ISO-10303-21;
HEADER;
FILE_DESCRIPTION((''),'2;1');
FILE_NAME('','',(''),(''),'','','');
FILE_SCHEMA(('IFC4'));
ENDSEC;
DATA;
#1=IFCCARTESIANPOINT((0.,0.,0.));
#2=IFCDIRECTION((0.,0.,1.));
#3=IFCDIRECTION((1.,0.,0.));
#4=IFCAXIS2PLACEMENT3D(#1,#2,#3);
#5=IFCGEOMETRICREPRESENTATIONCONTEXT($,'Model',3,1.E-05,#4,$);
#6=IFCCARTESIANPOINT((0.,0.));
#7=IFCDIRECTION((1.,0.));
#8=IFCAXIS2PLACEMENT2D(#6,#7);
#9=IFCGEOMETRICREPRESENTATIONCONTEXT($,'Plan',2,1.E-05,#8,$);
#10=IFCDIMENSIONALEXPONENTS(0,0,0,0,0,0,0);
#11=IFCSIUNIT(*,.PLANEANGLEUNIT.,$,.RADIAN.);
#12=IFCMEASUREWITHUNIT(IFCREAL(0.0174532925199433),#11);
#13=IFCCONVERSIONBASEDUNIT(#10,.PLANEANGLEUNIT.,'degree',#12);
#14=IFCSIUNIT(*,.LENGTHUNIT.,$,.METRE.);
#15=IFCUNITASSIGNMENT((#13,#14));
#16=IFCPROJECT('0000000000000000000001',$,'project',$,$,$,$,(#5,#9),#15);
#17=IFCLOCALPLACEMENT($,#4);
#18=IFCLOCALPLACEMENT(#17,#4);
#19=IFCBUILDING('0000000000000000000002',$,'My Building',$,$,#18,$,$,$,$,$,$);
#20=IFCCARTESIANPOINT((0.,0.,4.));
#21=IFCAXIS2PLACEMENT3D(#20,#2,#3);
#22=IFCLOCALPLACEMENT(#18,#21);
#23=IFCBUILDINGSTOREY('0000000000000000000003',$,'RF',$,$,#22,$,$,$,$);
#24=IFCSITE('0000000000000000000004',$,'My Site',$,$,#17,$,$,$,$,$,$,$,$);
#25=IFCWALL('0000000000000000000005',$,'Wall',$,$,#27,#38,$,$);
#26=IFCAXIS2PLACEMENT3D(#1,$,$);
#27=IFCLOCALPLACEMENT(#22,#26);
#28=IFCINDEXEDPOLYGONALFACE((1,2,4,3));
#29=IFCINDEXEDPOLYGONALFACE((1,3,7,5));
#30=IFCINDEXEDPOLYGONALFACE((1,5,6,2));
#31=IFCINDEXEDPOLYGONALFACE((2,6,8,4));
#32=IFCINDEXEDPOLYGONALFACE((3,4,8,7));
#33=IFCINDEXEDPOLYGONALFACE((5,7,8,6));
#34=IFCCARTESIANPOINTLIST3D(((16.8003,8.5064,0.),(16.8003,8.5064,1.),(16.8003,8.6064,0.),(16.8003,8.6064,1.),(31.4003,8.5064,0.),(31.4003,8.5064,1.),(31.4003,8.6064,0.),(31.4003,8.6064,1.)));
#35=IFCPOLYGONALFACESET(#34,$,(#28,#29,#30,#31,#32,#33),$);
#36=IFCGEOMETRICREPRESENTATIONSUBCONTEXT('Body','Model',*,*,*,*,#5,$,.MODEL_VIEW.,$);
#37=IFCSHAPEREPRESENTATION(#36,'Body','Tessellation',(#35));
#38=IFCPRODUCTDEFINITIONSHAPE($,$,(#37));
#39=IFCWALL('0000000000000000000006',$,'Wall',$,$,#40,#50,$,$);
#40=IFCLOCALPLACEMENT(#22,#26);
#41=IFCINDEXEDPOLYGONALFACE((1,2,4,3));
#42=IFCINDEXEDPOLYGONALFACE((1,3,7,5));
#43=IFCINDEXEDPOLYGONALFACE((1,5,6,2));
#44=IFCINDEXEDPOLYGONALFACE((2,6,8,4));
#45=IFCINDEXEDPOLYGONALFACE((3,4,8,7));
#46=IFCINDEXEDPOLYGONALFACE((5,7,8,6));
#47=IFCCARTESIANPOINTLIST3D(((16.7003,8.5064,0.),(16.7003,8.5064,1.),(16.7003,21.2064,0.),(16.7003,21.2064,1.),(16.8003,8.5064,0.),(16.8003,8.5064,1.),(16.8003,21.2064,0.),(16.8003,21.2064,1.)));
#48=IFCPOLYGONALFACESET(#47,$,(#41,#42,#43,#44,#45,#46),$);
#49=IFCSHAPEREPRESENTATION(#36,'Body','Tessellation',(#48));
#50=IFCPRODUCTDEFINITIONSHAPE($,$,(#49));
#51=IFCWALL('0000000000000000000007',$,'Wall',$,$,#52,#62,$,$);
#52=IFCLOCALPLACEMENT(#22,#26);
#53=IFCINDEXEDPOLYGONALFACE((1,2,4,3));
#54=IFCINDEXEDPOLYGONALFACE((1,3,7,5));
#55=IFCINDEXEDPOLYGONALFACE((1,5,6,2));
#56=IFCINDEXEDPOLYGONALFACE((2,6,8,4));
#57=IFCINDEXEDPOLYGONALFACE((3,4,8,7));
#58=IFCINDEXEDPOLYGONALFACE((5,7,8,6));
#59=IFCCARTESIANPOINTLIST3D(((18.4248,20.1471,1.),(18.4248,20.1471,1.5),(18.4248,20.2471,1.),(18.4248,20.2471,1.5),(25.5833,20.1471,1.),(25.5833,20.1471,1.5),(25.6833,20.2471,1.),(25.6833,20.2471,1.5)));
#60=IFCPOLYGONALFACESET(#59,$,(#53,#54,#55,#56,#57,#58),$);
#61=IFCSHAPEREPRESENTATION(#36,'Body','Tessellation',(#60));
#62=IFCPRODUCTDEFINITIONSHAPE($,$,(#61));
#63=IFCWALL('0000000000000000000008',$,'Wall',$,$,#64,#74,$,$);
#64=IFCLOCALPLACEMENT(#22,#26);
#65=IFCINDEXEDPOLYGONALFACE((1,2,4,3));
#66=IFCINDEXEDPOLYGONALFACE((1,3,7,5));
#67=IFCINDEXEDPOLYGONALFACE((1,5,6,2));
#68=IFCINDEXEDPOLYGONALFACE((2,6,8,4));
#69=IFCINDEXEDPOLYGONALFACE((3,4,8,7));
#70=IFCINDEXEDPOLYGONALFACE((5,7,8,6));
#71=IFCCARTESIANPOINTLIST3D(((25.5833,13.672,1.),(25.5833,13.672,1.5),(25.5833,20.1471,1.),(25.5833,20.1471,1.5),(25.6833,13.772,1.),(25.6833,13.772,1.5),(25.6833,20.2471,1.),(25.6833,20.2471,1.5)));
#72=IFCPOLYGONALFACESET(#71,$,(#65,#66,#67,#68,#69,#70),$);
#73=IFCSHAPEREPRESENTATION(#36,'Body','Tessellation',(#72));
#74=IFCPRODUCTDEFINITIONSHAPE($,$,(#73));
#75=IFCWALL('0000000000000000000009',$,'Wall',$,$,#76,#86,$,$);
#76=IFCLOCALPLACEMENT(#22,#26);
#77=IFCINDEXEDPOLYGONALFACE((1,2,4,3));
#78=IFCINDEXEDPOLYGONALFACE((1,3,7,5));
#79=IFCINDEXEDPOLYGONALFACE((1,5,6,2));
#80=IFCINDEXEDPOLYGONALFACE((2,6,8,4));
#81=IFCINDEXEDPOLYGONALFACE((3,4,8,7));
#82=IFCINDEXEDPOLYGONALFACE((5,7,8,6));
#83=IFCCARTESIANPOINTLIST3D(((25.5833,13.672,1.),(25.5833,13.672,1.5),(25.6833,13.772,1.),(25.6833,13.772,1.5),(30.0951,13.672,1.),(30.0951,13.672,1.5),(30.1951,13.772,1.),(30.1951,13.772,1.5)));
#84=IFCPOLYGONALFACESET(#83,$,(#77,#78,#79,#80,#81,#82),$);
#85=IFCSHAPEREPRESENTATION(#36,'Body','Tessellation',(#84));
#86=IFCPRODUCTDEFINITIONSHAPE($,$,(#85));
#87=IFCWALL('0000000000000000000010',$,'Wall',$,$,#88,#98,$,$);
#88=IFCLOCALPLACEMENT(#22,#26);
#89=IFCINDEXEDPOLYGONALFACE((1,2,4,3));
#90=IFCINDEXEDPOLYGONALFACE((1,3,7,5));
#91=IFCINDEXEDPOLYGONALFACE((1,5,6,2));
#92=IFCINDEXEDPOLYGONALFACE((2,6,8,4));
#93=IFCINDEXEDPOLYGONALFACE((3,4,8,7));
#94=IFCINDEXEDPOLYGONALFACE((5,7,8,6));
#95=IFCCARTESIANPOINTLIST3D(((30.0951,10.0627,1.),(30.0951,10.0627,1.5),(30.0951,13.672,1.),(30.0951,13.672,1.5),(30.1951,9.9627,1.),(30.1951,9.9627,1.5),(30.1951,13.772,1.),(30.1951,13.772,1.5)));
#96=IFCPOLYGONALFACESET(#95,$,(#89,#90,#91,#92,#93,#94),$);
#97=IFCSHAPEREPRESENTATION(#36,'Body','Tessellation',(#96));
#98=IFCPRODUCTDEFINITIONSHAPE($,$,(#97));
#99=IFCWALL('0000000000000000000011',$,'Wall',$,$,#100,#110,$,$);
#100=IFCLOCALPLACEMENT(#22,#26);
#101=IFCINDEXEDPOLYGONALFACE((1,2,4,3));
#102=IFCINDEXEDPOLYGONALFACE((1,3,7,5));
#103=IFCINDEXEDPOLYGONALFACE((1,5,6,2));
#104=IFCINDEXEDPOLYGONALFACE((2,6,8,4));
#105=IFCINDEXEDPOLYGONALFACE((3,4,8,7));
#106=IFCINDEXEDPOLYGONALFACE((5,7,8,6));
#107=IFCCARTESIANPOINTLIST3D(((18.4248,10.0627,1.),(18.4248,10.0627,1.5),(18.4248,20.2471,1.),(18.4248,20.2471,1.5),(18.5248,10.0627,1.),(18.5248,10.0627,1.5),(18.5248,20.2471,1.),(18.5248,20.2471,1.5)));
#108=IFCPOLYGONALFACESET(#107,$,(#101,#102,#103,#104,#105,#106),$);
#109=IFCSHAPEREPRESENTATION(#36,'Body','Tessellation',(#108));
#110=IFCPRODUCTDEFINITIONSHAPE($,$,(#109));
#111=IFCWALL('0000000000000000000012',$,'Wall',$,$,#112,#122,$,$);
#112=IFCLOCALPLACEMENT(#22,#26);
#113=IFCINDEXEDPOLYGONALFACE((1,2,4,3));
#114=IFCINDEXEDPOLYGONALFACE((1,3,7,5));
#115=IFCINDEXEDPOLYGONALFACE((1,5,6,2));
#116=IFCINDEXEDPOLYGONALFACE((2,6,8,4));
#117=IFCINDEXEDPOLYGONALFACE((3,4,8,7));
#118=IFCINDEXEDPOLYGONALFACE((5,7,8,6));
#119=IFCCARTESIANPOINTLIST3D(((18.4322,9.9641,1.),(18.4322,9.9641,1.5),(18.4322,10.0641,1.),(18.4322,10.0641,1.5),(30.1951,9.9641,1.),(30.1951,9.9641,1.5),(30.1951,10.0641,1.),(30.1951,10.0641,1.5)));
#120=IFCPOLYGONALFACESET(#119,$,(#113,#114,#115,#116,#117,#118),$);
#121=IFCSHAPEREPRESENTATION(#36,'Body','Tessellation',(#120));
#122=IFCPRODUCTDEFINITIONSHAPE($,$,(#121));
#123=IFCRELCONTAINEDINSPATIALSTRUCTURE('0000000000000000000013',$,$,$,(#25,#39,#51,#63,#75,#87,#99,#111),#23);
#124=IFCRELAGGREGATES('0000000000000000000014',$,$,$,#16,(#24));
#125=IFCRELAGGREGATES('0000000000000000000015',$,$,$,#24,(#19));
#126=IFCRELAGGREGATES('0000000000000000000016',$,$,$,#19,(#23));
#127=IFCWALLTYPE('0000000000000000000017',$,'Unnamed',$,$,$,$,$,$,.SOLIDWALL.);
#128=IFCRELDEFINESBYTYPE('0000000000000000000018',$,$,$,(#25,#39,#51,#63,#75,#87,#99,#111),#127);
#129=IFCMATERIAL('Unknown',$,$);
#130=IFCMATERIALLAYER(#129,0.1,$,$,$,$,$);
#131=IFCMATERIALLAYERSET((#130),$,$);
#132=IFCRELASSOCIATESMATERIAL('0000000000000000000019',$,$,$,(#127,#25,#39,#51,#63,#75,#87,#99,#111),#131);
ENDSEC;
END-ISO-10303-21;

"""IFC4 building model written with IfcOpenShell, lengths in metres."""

from ifc_helpers import new_model, entity, si_unit, converted_unit, frame, origin_with_axes, origin_2d_with_axis, place, context, subcontext, project, spatial, line, indexed_curve, outline, extrude, material, layer, layer_set, layer_usage, type_object, element, save


model = new_model("IFC4")

# Units and contexts
model_context = context("Model", 3, precision=1e-05, world=origin_with_axes())
plan_context = context("Plan", 2, precision=1e-05, world=origin_2d_with_axis())
body_context = subcontext(model_context, "Body", "Model", "MODEL_VIEW")
ifc_project = project(units=[converted_unit("PLANEANGLEUNIT", "degree", entity("IfcReal", 0.0174532925199433), si_unit("PLANEANGLEUNIT", "RADIAN"), dimensions=[0, 0, 0, 0, 0, 0, 0]), si_unit("LENGTHUNIT", "METRE")], contexts=[model_context, plan_context])

# Site, building, storey
site_placement = place(None, origin_with_axes())
site = spatial("IfcSite", under=ifc_project, at=site_placement, Name="My Site")
building_placement = place(site_placement, origin_with_axes())
building = spatial("IfcBuilding", under=site, at=building_placement, Name="My Building")
storey_placement = place(building_placement, frame((0.0, 0.0, 4.0), z_axis=(0.0, 0.0, 1.0), x_axis=(1.0, 0.0, 0.0)))
storey = spatial("IfcBuildingStorey", under=building, at=storey_placement, Name="RF")

# Shared definitions
ifc_material = material(Name="Unknown")

# Walls
ifc_layer_1 = layer(ifc_material, 0.1)
ifc_layer_set_1 = layer_set([ifc_layer_1])
wall_type = type_object("IfcWallType", Name="Unnamed", PredefinedType="SOLIDWALL", material=ifc_layer_set_1)
ifc_layer_usage_1 = layer_usage(ifc_layer_set_1, "AXIS2", "POSITIVE", 0.0)
wall_1_placement = place(storey_placement, frame((16.8003, 8.5064, 0.0), z_axis=(0.0, 0.0, 1.0), x_axis=(1.0, 0.0, 0.0)))
element("IfcWall", 1, at=wall_1_placement, inside=storey, type_object=wall_type, material=ifc_layer_usage_1, Name="Wall", context=body_context, shape_type="SweptSolid", body=[
    extrude(outline(indexed_curve([(0.0, 0.0), (0.0, 0.1), (14.6, 0.1), (14.6, 0.0)], segments=[line(1, 2, 3, 4, 1)])), origin_with_axes(), (0.0, 0.0, 1.0), 1.0),
])
ifc_layer_usage_2 = layer_usage(ifc_layer_set_1, "AXIS2", "POSITIVE", 0.0)
wall_2_placement = place(storey_placement, frame((16.7003, 21.2064, 0.0), z_axis=(0.0, 0.0, 1.0), x_axis=(0.0, -1.0, 0.0)))
element("IfcWall", 2, at=wall_2_placement, inside=storey, type_object=wall_type, material=ifc_layer_usage_2, Name="Wall", context=body_context, shape_type="SweptSolid", body=[
    extrude(outline(indexed_curve([(0.0, 0.0), (0.0, 0.1), (12.7, 0.1), (12.7, 0.0)], segments=[line(1, 2, 3, 4, 1)])), origin_with_axes(), (0.0, 0.0, 1.0), 1.0),
])
ifc_layer_usage_3 = layer_usage(ifc_layer_set_1, "AXIS2", "POSITIVE", 0.0)
wall_3_placement = place(storey_placement, frame((18.4248, 20.1471, 1.0), z_axis=(0.0, 0.0, 1.0), x_axis=(1.0, 0.0, 0.0)))
element("IfcWall", 3, at=wall_3_placement, inside=storey, type_object=wall_type, material=ifc_layer_usage_3, Name="Wall", context=body_context, shape_type="SweptSolid", body=[
    extrude(outline(indexed_curve([(0.0, 0.0), (0.0, 0.1), (7.2584, 0.1), (7.1584, 0.0)], segments=[line(1, 2, 3, 4, 1)])), origin_with_axes(), (0.0, 0.0, 1.0), 0.5),
])
ifc_layer_usage_4 = layer_usage(ifc_layer_set_1, "AXIS2", "POSITIVE", 0.0)
wall_4_placement = place(storey_placement, frame((25.5833, 20.1471, 1.0), z_axis=(0.0, 0.0, 1.0), x_axis=(0.0, -1.0, 0.0)))
element("IfcWall", 4, at=wall_4_placement, inside=storey, type_object=wall_type, material=ifc_layer_usage_4, Name="Wall", context=body_context, shape_type="SweptSolid", body=[
    extrude(outline(indexed_curve([(0.0, 0.0), (-0.1, 0.1), (6.3751, 0.1), (6.4751, 0.0)], segments=[line(1, 2, 3, 4, 1)])), origin_with_axes(), (0.0, 0.0, 1.0), 0.5),
])
ifc_layer_usage_5 = layer_usage(ifc_layer_set_1, "AXIS2", "POSITIVE", 0.0)
wall_5_placement = place(storey_placement, frame((25.5833, 13.672, 1.0), z_axis=(0.0, 0.0, 1.0), x_axis=(1.0, 0.0, 0.0)))
element("IfcWall", 5, at=wall_5_placement, inside=storey, type_object=wall_type, material=ifc_layer_usage_5, Name="Wall", context=body_context, shape_type="SweptSolid", body=[
    extrude(outline(indexed_curve([(0.0, 0.0), (0.1, 0.1), (4.6118, 0.1), (4.5118, 0.0)], segments=[line(1, 2, 3, 4, 1)])), origin_with_axes(), (0.0, 0.0, 1.0), 0.5),
])
ifc_layer_usage_6 = layer_usage(ifc_layer_set_1, "AXIS2", "POSITIVE", 0.0)
wall_6_placement = place(storey_placement, frame((30.0951, 13.672, 1.0), z_axis=(0.0, 0.0, 1.0), x_axis=(0.0, -1.0, 0.0)))
element("IfcWall", 6, at=wall_6_placement, inside=storey, type_object=wall_type, material=ifc_layer_usage_6, Name="Wall", context=body_context, shape_type="SweptSolid", body=[
    extrude(outline(indexed_curve([(0.0, 0.0), (-0.1, 0.1), (3.7093, 0.1), (3.6093, 0.0)], segments=[line(1, 2, 3, 4, 1)])), origin_with_axes(), (0.0, 0.0, 1.0), 0.5),
])
ifc_layer_usage_7 = layer_usage(ifc_layer_set_1, "AXIS2", "POSITIVE", 0.0)
wall_7_placement = place(storey_placement, frame((18.4248, 20.2471, 1.0), z_axis=(0.0, 0.0, 1.0), x_axis=(0.0, -1.0, 0.0)))
element("IfcWall", 7, at=wall_7_placement, inside=storey, type_object=wall_type, material=ifc_layer_usage_7, Name="Wall", context=body_context, shape_type="SweptSolid", body=[
    extrude(outline(indexed_curve([(0.0, 0.0), (0.0, 0.1), (10.1844, 0.1), (10.1844, 0.0)], segments=[line(1, 2, 3, 4, 1)])), origin_with_axes(), (0.0, 0.0, 1.0), 0.5),
])
ifc_layer_usage_8 = layer_usage(ifc_layer_set_1, "AXIS2", "POSITIVE", 0.0)
wall_8_placement = place(storey_placement, frame((18.4322, 9.9641, 1.0), z_axis=(0.0, 0.0, 1.0), x_axis=(1.0, 0.0, 0.0)))
element("IfcWall", 8, at=wall_8_placement, inside=storey, type_object=wall_type, material=ifc_layer_usage_8, Name="Wall", context=body_context, shape_type="SweptSolid", body=[
    extrude(outline(indexed_curve([(0.0, 0.0), (0.0, 0.1), (11.7629, 0.1), (11.7629, 0.0)], segments=[line(1, 2, 3, 4, 1)])), origin_with_axes(), (0.0, 0.0, 1.0), 0.5),
])

save(model, "model.ifc")
